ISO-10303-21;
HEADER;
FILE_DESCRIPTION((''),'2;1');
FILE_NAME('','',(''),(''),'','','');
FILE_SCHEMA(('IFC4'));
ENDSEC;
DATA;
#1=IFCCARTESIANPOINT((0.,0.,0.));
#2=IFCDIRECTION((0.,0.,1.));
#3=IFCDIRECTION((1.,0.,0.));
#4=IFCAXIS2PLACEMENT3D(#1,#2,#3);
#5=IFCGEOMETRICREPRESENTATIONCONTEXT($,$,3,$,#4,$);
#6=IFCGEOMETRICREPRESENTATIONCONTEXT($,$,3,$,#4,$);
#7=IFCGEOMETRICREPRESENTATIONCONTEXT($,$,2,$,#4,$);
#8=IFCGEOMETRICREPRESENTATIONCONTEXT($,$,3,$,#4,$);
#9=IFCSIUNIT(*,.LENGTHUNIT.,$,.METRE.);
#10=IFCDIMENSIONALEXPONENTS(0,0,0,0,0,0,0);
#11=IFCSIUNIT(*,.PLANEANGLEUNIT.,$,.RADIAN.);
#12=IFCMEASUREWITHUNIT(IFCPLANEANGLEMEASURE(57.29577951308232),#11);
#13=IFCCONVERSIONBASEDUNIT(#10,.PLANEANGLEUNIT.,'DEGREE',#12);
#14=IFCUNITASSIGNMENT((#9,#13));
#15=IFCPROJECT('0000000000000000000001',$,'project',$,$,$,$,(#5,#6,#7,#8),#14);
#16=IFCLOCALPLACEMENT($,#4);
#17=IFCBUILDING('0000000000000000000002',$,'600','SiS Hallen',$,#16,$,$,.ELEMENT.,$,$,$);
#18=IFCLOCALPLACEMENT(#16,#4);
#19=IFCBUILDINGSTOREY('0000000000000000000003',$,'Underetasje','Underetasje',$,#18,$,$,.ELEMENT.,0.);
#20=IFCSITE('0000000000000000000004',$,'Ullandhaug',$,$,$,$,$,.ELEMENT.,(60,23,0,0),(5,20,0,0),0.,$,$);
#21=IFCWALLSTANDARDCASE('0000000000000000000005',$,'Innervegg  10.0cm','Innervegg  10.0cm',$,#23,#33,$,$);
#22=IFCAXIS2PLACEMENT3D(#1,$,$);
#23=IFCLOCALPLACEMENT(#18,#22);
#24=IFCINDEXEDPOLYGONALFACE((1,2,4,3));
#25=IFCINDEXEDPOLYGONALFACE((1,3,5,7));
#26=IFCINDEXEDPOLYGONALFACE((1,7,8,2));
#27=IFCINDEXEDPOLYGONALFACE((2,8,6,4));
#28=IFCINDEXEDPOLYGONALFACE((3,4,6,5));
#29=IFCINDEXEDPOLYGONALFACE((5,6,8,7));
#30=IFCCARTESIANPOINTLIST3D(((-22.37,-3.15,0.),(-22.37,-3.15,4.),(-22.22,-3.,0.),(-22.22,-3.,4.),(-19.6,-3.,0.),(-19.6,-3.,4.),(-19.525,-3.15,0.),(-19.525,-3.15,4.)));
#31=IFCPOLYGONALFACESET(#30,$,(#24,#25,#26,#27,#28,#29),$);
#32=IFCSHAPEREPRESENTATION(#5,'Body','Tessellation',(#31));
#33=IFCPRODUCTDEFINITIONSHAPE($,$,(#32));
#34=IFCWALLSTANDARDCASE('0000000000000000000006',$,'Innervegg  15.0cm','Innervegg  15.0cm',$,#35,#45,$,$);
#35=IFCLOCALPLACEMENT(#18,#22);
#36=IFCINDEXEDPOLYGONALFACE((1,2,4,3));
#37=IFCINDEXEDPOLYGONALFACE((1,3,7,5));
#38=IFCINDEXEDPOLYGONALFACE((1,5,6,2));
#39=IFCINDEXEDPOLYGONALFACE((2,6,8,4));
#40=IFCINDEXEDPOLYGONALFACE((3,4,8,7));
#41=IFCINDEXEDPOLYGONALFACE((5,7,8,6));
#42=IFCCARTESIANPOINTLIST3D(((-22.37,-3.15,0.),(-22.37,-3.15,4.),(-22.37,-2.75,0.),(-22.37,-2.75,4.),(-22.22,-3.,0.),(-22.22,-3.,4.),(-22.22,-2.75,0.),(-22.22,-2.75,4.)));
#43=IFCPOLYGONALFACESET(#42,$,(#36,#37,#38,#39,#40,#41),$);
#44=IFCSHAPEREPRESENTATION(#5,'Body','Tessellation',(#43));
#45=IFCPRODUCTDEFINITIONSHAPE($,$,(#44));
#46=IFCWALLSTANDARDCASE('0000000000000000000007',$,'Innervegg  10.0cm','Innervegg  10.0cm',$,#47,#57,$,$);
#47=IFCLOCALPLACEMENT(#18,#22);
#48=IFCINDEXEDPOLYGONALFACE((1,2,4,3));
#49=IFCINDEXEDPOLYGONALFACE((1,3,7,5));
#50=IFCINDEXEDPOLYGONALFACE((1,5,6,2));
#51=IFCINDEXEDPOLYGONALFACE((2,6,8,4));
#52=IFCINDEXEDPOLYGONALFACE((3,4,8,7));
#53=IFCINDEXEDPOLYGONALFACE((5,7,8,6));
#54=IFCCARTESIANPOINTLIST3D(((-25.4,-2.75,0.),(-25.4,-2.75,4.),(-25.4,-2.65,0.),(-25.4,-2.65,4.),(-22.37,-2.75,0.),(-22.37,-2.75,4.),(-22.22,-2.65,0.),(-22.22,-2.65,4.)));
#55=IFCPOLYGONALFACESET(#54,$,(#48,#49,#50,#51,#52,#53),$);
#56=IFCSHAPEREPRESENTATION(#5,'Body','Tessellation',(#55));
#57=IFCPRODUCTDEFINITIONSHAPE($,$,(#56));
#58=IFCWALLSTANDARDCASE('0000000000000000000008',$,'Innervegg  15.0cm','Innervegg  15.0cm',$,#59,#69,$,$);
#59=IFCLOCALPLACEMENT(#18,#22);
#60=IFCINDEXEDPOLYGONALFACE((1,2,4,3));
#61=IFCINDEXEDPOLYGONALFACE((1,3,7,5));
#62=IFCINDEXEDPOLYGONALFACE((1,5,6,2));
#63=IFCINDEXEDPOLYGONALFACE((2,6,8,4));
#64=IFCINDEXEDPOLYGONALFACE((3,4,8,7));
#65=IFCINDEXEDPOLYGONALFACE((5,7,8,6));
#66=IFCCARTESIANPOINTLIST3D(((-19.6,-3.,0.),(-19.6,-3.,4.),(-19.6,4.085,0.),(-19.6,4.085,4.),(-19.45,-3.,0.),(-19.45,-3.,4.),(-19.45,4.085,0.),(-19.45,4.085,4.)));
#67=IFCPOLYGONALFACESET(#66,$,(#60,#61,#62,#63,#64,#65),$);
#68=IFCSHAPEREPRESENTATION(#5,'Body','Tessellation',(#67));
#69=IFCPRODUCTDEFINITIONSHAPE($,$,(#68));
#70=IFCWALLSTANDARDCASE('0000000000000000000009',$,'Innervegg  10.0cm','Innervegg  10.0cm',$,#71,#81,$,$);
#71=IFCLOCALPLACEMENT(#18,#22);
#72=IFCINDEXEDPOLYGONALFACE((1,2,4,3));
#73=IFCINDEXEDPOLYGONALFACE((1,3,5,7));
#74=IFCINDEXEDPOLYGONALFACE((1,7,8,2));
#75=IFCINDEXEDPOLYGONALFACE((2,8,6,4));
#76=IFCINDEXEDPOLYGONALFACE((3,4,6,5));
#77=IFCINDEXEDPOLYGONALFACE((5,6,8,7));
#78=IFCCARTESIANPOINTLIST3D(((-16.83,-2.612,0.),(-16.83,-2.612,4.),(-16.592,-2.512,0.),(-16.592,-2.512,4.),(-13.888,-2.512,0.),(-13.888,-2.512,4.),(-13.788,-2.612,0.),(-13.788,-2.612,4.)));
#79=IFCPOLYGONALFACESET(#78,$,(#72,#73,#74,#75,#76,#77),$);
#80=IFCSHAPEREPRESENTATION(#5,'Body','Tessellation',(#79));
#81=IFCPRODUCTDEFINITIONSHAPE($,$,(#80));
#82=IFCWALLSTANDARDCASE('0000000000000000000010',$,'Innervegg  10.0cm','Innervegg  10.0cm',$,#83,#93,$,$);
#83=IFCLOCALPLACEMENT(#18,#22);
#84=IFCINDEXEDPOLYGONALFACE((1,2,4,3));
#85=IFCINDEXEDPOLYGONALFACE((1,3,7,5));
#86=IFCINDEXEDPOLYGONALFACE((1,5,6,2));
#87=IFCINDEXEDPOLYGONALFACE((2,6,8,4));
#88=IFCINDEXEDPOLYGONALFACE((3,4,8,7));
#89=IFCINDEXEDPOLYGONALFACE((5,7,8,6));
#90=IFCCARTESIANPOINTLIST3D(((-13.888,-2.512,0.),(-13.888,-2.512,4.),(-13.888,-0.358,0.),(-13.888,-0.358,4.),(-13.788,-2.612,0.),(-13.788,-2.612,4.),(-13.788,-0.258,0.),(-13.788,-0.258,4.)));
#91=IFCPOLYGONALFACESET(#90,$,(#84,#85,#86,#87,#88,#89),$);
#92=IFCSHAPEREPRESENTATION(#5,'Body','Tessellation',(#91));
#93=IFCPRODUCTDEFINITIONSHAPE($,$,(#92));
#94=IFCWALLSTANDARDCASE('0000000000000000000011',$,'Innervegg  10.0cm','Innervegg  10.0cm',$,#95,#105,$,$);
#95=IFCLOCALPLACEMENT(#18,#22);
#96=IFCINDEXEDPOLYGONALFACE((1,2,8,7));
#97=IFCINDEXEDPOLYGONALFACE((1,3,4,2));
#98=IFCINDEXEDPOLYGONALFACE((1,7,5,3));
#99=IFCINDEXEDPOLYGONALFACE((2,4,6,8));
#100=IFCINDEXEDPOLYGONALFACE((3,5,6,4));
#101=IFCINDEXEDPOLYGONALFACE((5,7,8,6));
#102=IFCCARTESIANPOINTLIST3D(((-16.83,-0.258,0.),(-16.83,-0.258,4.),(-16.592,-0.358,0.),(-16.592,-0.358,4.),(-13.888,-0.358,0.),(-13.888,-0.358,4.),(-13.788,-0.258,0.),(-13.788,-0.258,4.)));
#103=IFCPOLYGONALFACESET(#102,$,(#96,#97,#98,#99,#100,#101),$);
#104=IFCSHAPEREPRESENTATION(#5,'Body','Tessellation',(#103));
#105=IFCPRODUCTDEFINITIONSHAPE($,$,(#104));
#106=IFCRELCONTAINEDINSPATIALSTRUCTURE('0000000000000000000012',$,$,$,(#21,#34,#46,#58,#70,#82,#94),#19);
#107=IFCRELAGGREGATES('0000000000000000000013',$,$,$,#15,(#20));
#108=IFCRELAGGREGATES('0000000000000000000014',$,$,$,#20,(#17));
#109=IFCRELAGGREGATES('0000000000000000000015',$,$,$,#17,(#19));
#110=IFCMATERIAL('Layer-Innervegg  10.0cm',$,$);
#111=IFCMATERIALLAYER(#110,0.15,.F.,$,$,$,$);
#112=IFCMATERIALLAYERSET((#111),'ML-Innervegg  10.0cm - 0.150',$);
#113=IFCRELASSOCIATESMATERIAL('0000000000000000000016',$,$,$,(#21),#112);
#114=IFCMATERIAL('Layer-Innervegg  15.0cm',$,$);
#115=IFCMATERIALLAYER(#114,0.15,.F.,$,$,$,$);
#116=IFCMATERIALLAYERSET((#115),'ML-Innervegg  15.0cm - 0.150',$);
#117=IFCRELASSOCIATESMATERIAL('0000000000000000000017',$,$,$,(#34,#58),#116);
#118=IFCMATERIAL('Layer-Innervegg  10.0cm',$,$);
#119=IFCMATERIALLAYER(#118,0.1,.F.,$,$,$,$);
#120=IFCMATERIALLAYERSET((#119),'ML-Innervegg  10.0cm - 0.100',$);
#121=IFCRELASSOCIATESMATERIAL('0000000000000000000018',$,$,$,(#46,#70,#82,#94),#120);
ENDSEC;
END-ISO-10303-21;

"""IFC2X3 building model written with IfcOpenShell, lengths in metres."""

from ifc_helpers import new_model, entity, si_unit, converted_unit, frame, origin_with_axes, place, context, project, spatial, polyline, outline, extrude, material, layer, layer_set, layer_usage, element, save


model = new_model("IFC2X3")

# Units and contexts
context_of_model_1 = context(None, 3, world=origin_with_axes())
context_of_model_2 = context(None, 3, world=origin_with_axes())
context_of_model_3 = context(None, 2, world=origin_with_axes())
context_of_model_4 = context(None, 3, world=origin_with_axes())
ifc_project = project(units=[si_unit("LENGTHUNIT", "METRE"), converted_unit("PLANEANGLEUNIT", "DEGREE", entity("IfcPlaneAngleMeasure", 57.29577951308232), si_unit("PLANEANGLEUNIT", "RADIAN"), dimensions=[0, 0, 0, 0, 0, 0, 0])], contexts=[context_of_model_1, context_of_model_2, context_of_model_3, context_of_model_4])

# Site, building, storey
site = spatial("IfcSite", under=ifc_project, Name="Ullandhaug", CompositionType="ELEMENT", RefLatitude=(60, 23, 0, 0), RefLongitude=(5, 20, 0, 0), RefElevation=0.0)
building_placement = place(None, origin_with_axes())
building = spatial("IfcBuilding", under=site, at=building_placement, Name="600", Description="SiS Hallen", CompositionType="ELEMENT")
storey_placement = place(building_placement, origin_with_axes())
storey = spatial("IfcBuildingStorey", under=building, at=storey_placement, Name="Underetasje", Description="Underetasje", CompositionType="ELEMENT", Elevation=0.0)

# Walls
ifc_material_1 = material(Name="Layer-Innervegg  10.0cm")
ifc_layer_1 = layer(ifc_material_1, 0.1, ventilated=False)
ifc_layer_set_1 = layer_set([ifc_layer_1], Name="ML-Innervegg  10.0cm - 0.100")
ifc_layer_usage_1 = layer_usage(ifc_layer_set_1, "AXIS2", "POSITIVE", 0.0)
ifc_material_2 = material(Name="Layer-Innervegg  10.0cm")
ifc_layer_2 = layer(ifc_material_2, 0.15, ventilated=False)
ifc_layer_set_2 = layer_set([ifc_layer_2], Name="ML-Innervegg  10.0cm - 0.150")
ifc_layer_usage_2 = layer_usage(ifc_layer_set_2, "AXIS2", "POSITIVE", 0.0)
wall_1_placement = place(storey_placement, frame((-19.6, -3.0, 0.0), z_axis=(0.0, 0.0, 1.0), x_axis=(-1.0, 0.0, 0.0)))
element("IfcWallStandardCase", 1, at=wall_1_placement, inside=storey, material=ifc_layer_usage_2, Name="Innervegg  10.0cm", Description="Innervegg  10.0cm", context=context_of_model_1, shape_type="SweptSolid", body=[
    extrude(outline(polyline([(0.0, 0.0), (2.62, 0.0), (2.77, 0.15), (-0.075, 0.15), (0.0, 0.0)])), frame((0.0, 0.0, 0.0), z_axis=(0.0, 0.0, 1.0), x_axis=(1.0, 0.0, 0.0)), (0.0, 0.0, 1.0), 4.0),
])
ifc_material_3 = material(Name="Layer-Innervegg  15.0cm")
ifc_layer_3 = layer(ifc_material_3, 0.15, ventilated=False)
ifc_layer_set_3 = layer_set([ifc_layer_3], Name="ML-Innervegg  15.0cm - 0.150")
ifc_layer_usage_3 = layer_usage(ifc_layer_set_3, "AXIS2", "POSITIVE", 0.0)
wall_2_placement = place(storey_placement, frame((-22.22, -3.0, 0.0), z_axis=(0.0, 0.0, 1.0), x_axis=(0.0, 1.0, 0.0)))
element("IfcWallStandardCase", 2, at=wall_2_placement, inside=storey, material=ifc_layer_usage_3, Name="Innervegg  15.0cm", Description="Innervegg  15.0cm", context=context_of_model_1, shape_type="SweptSolid", body=[
    extrude(outline(polyline([(0.0, 0.0), (0.25, 0.0), (0.25, 0.15), (-0.15, 0.15), (0.0, 0.0)])), frame((0.0, 0.0, 0.0), z_axis=(0.0, 0.0, 1.0), x_axis=(1.0, 0.0, 0.0)), (0.0, 0.0, 1.0), 4.0),
])
wall_3_placement = place(storey_placement, frame((-22.22, -2.65, 0.0), z_axis=(0.0, 0.0, 1.0), x_axis=(-1.0, 0.0, 0.0)))
element("IfcWallStandardCase", 3, at=wall_3_placement, inside=storey, material=ifc_layer_usage_1, Name="Innervegg  10.0cm", Description="Innervegg  10.0cm", context=context_of_model_1, shape_type="SweptSolid", body=[
    extrude(outline(polyline([(0.0, 0.0), (3.18, 0.0), (3.18, 0.1), (0.15, 0.1), (0.0, 0.0)])), frame((0.0, 0.0, 0.0), z_axis=(0.0, 0.0, 1.0), x_axis=(1.0, 0.0, 0.0)), (0.0, 0.0, 1.0), 4.0),
])
wall_4_placement = place(storey_placement, frame((-19.45, -3.0, 0.0), z_axis=(0.0, 0.0, 1.0), x_axis=(0.0, 1.0, 0.0)))
element("IfcWallStandardCase", 4, at=wall_4_placement, inside=storey, material=ifc_layer_usage_3, Name="Innervegg  15.0cm", Description="Innervegg  15.0cm", context=context_of_model_1, shape_type="SweptSolid", body=[
    extrude(outline(polyline([(0.0, 0.0), (7.085, 0.0), (7.085, 0.15), (0.0, 0.15), (0.0, 0.0)])), frame((0.0, 0.0, 0.0), z_axis=(0.0, 0.0, 1.0), x_axis=(1.0, 0.0, 0.0)), (0.0, 0.0, 1.0), 4.0),
])
wall_5_placement = place(storey_placement, frame((-16.83, -2.612, 0.0), z_axis=(0.0, 0.0, 1.0), x_axis=(1.0, 0.0, 0.0)))
element("IfcWallStandardCase", 5, at=wall_5_placement, inside=storey, material=ifc_layer_usage_1, Name="Innervegg  10.0cm", Description="Innervegg  10.0cm", context=context_of_model_1, shape_type="SweptSolid", body=[
    extrude(outline(polyline([(0.0, 0.0), (3.042, 0.0), (2.942, 0.1), (0.238, 0.1), (0.0, 0.0)])), origin_with_axes(), (0.0, 0.0, 1.0), 4.0),
])
wall_6_placement = place(storey_placement, frame((-13.788, -2.612, 0.0), z_axis=(0.0, 0.0, 1.0), x_axis=(0.0, 1.0, 0.0)))
element("IfcWallStandardCase", 6, at=wall_6_placement, inside=storey, material=ifc_layer_usage_1, Name="Innervegg  10.0cm", Description="Innervegg  10.0cm", context=context_of_model_1, shape_type="SweptSolid", body=[
    extrude(outline(polyline([(0.0, 0.0), (2.354, 0.0), (2.254, 0.1), (0.1, 0.1), (0.0, 0.0)])), frame((0.0, 0.0, 0.0), z_axis=(0.0, 0.0, 1.0), x_axis=(1.0, 0.0, 0.0)), (0.0, 0.0, 1.0), 4.0),
])
wall_7_placement = place(storey_placement, frame((-13.788, -0.258, 0.0), z_axis=(0.0, 0.0, 1.0), x_axis=(-1.0, 0.0, 0.0)))
element("IfcWallStandardCase", 7, at=wall_7_placement, inside=storey, material=ifc_layer_usage_1, Name="Innervegg  10.0cm", Description="Innervegg  10.0cm", context=context_of_model_1, shape_type="SweptSolid", body=[
    extrude(outline(polyline([(0.0, 0.0), (3.042, 0.0), (2.804, 0.1), (0.1, 0.1), (0.0, 0.0)])), frame((0.0, 0.0, 0.0), z_axis=(0.0, 0.0, 1.0), x_axis=(1.0, 0.0, 0.0)), (0.0, 0.0, 1.0), 4.0),
])

save(model, "model.ifc")
